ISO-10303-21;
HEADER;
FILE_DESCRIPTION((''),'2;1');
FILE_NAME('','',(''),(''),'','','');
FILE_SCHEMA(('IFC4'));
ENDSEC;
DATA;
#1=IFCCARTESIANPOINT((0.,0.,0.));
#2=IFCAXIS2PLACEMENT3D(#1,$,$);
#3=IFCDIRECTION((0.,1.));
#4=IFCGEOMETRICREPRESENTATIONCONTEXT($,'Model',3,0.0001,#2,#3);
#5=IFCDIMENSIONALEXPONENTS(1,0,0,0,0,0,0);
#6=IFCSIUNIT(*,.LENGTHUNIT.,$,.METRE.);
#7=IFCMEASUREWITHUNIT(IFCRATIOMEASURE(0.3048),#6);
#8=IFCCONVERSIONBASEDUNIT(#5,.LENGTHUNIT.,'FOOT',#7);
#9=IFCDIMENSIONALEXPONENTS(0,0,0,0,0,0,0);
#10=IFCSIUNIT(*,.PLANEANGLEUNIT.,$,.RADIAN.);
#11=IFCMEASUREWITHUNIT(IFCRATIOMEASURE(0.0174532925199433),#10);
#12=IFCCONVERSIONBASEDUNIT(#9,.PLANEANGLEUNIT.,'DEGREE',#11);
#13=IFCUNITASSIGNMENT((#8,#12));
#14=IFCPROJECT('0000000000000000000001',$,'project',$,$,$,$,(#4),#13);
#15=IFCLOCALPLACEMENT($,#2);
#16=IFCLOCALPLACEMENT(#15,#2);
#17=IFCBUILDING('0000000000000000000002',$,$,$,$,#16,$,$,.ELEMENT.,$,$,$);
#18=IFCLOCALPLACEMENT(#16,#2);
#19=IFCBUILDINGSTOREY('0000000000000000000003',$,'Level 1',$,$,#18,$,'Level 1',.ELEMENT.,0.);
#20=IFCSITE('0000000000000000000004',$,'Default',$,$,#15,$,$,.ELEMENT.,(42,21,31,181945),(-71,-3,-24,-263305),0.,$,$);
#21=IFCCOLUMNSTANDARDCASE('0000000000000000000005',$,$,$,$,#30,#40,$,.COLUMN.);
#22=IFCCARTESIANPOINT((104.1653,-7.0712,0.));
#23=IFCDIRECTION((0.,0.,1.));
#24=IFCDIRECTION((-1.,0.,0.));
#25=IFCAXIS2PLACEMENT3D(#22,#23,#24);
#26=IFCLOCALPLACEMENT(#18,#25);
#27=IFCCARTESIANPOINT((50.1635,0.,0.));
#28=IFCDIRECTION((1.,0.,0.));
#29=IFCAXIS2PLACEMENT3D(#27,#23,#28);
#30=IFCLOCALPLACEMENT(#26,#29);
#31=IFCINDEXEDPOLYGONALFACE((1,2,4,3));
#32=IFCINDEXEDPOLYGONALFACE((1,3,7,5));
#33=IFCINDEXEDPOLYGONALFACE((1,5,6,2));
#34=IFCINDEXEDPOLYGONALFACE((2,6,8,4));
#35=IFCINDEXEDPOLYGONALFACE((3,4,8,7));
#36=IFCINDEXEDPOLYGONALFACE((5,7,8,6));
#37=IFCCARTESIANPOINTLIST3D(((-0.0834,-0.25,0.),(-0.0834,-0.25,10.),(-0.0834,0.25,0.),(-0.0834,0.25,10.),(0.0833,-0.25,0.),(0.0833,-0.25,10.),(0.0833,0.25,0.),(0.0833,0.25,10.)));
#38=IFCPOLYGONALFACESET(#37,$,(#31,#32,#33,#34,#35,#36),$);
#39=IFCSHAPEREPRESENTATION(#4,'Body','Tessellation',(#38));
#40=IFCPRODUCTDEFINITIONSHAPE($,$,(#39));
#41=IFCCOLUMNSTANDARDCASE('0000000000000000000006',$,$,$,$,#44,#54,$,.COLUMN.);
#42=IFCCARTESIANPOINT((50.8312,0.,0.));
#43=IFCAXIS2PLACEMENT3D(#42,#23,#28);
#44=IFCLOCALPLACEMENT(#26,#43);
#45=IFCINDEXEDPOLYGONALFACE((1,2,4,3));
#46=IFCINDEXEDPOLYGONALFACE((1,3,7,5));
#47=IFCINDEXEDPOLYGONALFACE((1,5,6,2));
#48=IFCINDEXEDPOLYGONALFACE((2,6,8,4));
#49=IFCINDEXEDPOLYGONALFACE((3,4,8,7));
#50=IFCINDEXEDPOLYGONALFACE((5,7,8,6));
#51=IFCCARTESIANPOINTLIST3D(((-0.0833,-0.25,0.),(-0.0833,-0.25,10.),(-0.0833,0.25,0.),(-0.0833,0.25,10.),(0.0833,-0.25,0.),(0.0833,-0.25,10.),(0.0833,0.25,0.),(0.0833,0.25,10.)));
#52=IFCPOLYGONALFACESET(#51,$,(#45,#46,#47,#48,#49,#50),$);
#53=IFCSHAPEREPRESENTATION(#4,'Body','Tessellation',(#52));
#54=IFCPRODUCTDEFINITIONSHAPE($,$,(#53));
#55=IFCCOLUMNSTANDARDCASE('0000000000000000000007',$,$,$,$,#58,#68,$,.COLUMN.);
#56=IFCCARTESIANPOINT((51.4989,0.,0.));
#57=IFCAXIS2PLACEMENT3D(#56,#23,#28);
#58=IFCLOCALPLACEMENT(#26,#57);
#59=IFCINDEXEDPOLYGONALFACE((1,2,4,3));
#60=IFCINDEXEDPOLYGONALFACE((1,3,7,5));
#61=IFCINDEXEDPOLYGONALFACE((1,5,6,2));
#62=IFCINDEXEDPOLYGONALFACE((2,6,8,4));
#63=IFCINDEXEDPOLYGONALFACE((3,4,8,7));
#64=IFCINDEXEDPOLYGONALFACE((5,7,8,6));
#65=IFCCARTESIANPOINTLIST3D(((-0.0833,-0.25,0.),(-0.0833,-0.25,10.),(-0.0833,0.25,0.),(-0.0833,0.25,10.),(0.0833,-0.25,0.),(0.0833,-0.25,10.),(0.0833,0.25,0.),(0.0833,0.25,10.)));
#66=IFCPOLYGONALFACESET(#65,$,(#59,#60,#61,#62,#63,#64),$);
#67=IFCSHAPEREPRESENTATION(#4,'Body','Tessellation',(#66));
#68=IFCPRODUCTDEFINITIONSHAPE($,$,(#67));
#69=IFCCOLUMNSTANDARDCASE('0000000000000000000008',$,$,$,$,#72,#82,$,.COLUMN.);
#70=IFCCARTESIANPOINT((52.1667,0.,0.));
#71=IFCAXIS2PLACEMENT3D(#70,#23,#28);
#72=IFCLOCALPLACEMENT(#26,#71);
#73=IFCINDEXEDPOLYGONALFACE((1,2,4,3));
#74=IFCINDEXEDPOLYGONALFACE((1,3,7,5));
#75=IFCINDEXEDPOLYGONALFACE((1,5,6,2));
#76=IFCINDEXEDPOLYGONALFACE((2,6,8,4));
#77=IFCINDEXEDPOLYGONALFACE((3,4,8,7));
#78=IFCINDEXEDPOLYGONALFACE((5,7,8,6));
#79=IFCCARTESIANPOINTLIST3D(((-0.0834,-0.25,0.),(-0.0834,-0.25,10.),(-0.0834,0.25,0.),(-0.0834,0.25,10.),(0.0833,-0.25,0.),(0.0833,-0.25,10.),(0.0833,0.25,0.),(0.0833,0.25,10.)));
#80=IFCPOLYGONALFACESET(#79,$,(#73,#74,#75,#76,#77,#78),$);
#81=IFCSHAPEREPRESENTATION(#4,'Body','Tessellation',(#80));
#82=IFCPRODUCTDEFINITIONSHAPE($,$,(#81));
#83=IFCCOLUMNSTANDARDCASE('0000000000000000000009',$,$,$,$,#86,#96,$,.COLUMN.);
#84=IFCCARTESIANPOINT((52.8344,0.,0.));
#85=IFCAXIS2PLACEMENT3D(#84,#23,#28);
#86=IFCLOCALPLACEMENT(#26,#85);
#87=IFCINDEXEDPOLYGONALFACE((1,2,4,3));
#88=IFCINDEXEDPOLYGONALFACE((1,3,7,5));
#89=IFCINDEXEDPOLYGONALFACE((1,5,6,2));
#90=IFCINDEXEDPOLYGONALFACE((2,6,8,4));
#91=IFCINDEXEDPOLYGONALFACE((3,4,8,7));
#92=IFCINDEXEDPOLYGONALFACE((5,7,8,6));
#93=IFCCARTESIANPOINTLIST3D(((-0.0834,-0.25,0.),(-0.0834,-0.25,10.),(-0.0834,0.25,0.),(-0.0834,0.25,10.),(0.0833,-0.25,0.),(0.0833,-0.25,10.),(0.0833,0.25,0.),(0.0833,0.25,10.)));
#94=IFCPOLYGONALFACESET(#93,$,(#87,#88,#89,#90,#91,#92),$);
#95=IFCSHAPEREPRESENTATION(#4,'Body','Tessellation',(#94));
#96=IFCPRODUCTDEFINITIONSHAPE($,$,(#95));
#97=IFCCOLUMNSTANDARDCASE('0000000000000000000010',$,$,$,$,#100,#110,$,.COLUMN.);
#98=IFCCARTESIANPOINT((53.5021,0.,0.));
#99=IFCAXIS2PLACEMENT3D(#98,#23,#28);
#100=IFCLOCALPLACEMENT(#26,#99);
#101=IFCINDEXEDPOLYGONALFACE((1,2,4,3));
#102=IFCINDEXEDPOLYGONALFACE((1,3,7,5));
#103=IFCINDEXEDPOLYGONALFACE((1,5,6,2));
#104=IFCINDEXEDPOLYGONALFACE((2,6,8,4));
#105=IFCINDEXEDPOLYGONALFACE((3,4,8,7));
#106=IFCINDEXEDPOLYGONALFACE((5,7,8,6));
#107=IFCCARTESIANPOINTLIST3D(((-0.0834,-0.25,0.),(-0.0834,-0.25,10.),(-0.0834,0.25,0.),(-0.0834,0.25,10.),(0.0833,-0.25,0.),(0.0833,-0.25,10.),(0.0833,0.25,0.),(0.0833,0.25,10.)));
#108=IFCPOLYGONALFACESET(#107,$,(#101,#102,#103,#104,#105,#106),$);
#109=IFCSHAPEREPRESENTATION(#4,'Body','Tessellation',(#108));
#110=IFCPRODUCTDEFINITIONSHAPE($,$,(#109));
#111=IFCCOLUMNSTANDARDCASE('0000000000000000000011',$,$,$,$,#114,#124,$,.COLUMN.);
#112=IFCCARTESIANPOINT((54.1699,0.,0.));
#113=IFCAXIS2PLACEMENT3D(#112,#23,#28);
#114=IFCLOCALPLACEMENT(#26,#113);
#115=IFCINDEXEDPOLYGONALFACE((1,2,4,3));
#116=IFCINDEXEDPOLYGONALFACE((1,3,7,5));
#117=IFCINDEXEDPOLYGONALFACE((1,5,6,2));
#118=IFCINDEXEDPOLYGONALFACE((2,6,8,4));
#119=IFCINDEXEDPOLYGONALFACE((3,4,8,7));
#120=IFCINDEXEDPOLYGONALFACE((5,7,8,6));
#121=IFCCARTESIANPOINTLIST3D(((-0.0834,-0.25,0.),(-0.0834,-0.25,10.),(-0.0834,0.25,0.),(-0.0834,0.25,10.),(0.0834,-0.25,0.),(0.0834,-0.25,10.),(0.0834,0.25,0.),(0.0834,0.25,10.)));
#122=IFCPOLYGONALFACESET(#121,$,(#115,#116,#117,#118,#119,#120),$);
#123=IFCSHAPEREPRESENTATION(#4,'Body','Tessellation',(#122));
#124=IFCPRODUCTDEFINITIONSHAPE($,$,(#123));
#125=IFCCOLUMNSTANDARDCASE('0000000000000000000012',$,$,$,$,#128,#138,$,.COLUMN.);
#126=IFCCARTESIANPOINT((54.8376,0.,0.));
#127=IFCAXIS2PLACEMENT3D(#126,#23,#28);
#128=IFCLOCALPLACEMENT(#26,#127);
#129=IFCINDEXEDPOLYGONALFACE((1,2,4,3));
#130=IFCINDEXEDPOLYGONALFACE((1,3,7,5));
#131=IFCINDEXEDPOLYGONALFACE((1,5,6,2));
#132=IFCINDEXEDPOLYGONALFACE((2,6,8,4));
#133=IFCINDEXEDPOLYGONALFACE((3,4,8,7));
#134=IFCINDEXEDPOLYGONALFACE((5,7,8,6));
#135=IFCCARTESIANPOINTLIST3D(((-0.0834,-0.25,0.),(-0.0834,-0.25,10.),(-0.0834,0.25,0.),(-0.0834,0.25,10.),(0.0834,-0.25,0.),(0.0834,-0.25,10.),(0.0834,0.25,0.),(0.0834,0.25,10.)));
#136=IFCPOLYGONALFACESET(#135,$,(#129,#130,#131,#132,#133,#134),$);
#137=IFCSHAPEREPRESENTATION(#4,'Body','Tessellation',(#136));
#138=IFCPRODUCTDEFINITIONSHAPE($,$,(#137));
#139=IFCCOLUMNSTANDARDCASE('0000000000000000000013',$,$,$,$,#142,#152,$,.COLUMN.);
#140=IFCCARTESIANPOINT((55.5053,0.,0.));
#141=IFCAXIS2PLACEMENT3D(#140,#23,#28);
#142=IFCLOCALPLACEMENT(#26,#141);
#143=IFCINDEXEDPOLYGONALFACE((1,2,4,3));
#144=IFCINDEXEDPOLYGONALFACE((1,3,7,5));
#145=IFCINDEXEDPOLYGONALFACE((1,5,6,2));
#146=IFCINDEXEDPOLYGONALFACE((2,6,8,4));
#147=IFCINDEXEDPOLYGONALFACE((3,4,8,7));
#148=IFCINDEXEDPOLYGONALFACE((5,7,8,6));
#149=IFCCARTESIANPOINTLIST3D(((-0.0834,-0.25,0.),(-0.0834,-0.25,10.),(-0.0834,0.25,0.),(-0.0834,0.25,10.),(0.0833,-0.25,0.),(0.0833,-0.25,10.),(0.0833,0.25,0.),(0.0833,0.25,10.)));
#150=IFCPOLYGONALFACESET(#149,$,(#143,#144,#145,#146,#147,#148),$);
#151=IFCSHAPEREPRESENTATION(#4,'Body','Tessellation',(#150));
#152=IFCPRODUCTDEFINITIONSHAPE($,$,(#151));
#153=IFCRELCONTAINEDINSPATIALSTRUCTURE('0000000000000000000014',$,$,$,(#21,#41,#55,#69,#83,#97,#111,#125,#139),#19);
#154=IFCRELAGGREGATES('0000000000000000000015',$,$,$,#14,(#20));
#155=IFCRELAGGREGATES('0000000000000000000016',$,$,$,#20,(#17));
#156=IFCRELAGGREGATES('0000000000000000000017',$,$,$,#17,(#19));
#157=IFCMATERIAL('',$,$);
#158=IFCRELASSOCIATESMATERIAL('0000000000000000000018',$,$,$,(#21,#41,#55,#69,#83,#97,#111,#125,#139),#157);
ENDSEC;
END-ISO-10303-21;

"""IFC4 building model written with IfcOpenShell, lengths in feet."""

from ifc_helpers import new_model, entity, si_unit, converted_unit, direction, frame, origin, place, context, project, spatial, rectangle, extrude, material, element, save


model = new_model("IFC4")

# Units and contexts
model_context = context("Model", 3, precision=0.0001, world=origin(), true_north=direction((0.0, 1.0)))
ifc_project = project(units=[converted_unit("LENGTHUNIT", "FOOT", entity("IfcRatioMeasure", 0.3048), si_unit("LENGTHUNIT", "METRE"), dimensions=[1, 0, 0, 0, 0, 0, 0]), converted_unit("PLANEANGLEUNIT", "DEGREE", entity("IfcRatioMeasure", 0.0174532925199433), si_unit("PLANEANGLEUNIT", "RADIAN"), dimensions=[0, 0, 0, 0, 0, 0, 0])], contexts=[model_context])

# Site, building, storey
site_placement = place(None, origin())
site = spatial("IfcSite", under=ifc_project, at=site_placement, Name="Default", CompositionType="ELEMENT", RefLatitude=(42, 21, 31, 181945), RefLongitude=(-71, -3, -24, -263305), RefElevation=0.0)
building_placement = place(site_placement, origin())
building = spatial("IfcBuilding", under=site, at=building_placement, CompositionType="ELEMENT")
storey_placement = place(building_placement, origin())
storey = spatial("IfcBuildingStorey", under=building, at=storey_placement, Name="Level 1", LongName="Level 1", CompositionType="ELEMENT", Elevation=0.0)

# Columns
ifc_material_1 = material(Name="")
placement = place(storey_placement, frame((104.1653, -7.0712, 0.0), z_axis=(0.0, 0.0, 1.0), x_axis=(-1.0, 0.0, 0.0)))
for number, where, z_axis, x_axis in (
    (1, (50.1635, 0.0, 0.0), (0.0, 0.0, 1.0), (1.0, 0.0, 0.0)),
    (2, (50.8312, 0.0, 0.0), (0.0, 0.0, 1.0), (1.0, 0.0, 0.0)),
    (3, (51.4989, 0.0, 0.0), (0.0, 0.0, 1.0), (1.0, 0.0, 0.0)),
    (4, (52.1667, 0.0, 0.0), (0.0, 0.0, 1.0), (1.0, 0.0, 0.0)),
    (5, (52.8344, 0.0, 0.0), (0.0, 0.0, 1.0), (1.0, 0.0, 0.0)),
    (6, (53.5021, 0.0, 0.0), (0.0, 0.0, 1.0), (1.0, 0.0, 0.0)),
    (7, (54.1699, 0.0, 0.0), (0.0, 0.0, 1.0), (1.0, 0.0, 0.0)),
    (8, (54.8376, 0.0, 0.0), (0.0, 0.0, 1.0), (1.0, 0.0, 0.0)),
    (9, (55.5053, 0.0, 0.0), (0.0, 0.0, 1.0), (1.0, 0.0, 0.0)),
):
    element("IfcColumnStandardCase", number, at=place(placement, frame(where, z_axis=z_axis, x_axis=x_axis)), inside=storey, material=ifc_material_1, PredefinedType="COLUMN", context=model_context, shape_type="SweptSolid", body=[
        extrude(rectangle(XDim=0.1667, YDim=0.5), origin(), (0.0, 0.0, 1.0), 10.0),
    ])

save(model, "model.ifc")
